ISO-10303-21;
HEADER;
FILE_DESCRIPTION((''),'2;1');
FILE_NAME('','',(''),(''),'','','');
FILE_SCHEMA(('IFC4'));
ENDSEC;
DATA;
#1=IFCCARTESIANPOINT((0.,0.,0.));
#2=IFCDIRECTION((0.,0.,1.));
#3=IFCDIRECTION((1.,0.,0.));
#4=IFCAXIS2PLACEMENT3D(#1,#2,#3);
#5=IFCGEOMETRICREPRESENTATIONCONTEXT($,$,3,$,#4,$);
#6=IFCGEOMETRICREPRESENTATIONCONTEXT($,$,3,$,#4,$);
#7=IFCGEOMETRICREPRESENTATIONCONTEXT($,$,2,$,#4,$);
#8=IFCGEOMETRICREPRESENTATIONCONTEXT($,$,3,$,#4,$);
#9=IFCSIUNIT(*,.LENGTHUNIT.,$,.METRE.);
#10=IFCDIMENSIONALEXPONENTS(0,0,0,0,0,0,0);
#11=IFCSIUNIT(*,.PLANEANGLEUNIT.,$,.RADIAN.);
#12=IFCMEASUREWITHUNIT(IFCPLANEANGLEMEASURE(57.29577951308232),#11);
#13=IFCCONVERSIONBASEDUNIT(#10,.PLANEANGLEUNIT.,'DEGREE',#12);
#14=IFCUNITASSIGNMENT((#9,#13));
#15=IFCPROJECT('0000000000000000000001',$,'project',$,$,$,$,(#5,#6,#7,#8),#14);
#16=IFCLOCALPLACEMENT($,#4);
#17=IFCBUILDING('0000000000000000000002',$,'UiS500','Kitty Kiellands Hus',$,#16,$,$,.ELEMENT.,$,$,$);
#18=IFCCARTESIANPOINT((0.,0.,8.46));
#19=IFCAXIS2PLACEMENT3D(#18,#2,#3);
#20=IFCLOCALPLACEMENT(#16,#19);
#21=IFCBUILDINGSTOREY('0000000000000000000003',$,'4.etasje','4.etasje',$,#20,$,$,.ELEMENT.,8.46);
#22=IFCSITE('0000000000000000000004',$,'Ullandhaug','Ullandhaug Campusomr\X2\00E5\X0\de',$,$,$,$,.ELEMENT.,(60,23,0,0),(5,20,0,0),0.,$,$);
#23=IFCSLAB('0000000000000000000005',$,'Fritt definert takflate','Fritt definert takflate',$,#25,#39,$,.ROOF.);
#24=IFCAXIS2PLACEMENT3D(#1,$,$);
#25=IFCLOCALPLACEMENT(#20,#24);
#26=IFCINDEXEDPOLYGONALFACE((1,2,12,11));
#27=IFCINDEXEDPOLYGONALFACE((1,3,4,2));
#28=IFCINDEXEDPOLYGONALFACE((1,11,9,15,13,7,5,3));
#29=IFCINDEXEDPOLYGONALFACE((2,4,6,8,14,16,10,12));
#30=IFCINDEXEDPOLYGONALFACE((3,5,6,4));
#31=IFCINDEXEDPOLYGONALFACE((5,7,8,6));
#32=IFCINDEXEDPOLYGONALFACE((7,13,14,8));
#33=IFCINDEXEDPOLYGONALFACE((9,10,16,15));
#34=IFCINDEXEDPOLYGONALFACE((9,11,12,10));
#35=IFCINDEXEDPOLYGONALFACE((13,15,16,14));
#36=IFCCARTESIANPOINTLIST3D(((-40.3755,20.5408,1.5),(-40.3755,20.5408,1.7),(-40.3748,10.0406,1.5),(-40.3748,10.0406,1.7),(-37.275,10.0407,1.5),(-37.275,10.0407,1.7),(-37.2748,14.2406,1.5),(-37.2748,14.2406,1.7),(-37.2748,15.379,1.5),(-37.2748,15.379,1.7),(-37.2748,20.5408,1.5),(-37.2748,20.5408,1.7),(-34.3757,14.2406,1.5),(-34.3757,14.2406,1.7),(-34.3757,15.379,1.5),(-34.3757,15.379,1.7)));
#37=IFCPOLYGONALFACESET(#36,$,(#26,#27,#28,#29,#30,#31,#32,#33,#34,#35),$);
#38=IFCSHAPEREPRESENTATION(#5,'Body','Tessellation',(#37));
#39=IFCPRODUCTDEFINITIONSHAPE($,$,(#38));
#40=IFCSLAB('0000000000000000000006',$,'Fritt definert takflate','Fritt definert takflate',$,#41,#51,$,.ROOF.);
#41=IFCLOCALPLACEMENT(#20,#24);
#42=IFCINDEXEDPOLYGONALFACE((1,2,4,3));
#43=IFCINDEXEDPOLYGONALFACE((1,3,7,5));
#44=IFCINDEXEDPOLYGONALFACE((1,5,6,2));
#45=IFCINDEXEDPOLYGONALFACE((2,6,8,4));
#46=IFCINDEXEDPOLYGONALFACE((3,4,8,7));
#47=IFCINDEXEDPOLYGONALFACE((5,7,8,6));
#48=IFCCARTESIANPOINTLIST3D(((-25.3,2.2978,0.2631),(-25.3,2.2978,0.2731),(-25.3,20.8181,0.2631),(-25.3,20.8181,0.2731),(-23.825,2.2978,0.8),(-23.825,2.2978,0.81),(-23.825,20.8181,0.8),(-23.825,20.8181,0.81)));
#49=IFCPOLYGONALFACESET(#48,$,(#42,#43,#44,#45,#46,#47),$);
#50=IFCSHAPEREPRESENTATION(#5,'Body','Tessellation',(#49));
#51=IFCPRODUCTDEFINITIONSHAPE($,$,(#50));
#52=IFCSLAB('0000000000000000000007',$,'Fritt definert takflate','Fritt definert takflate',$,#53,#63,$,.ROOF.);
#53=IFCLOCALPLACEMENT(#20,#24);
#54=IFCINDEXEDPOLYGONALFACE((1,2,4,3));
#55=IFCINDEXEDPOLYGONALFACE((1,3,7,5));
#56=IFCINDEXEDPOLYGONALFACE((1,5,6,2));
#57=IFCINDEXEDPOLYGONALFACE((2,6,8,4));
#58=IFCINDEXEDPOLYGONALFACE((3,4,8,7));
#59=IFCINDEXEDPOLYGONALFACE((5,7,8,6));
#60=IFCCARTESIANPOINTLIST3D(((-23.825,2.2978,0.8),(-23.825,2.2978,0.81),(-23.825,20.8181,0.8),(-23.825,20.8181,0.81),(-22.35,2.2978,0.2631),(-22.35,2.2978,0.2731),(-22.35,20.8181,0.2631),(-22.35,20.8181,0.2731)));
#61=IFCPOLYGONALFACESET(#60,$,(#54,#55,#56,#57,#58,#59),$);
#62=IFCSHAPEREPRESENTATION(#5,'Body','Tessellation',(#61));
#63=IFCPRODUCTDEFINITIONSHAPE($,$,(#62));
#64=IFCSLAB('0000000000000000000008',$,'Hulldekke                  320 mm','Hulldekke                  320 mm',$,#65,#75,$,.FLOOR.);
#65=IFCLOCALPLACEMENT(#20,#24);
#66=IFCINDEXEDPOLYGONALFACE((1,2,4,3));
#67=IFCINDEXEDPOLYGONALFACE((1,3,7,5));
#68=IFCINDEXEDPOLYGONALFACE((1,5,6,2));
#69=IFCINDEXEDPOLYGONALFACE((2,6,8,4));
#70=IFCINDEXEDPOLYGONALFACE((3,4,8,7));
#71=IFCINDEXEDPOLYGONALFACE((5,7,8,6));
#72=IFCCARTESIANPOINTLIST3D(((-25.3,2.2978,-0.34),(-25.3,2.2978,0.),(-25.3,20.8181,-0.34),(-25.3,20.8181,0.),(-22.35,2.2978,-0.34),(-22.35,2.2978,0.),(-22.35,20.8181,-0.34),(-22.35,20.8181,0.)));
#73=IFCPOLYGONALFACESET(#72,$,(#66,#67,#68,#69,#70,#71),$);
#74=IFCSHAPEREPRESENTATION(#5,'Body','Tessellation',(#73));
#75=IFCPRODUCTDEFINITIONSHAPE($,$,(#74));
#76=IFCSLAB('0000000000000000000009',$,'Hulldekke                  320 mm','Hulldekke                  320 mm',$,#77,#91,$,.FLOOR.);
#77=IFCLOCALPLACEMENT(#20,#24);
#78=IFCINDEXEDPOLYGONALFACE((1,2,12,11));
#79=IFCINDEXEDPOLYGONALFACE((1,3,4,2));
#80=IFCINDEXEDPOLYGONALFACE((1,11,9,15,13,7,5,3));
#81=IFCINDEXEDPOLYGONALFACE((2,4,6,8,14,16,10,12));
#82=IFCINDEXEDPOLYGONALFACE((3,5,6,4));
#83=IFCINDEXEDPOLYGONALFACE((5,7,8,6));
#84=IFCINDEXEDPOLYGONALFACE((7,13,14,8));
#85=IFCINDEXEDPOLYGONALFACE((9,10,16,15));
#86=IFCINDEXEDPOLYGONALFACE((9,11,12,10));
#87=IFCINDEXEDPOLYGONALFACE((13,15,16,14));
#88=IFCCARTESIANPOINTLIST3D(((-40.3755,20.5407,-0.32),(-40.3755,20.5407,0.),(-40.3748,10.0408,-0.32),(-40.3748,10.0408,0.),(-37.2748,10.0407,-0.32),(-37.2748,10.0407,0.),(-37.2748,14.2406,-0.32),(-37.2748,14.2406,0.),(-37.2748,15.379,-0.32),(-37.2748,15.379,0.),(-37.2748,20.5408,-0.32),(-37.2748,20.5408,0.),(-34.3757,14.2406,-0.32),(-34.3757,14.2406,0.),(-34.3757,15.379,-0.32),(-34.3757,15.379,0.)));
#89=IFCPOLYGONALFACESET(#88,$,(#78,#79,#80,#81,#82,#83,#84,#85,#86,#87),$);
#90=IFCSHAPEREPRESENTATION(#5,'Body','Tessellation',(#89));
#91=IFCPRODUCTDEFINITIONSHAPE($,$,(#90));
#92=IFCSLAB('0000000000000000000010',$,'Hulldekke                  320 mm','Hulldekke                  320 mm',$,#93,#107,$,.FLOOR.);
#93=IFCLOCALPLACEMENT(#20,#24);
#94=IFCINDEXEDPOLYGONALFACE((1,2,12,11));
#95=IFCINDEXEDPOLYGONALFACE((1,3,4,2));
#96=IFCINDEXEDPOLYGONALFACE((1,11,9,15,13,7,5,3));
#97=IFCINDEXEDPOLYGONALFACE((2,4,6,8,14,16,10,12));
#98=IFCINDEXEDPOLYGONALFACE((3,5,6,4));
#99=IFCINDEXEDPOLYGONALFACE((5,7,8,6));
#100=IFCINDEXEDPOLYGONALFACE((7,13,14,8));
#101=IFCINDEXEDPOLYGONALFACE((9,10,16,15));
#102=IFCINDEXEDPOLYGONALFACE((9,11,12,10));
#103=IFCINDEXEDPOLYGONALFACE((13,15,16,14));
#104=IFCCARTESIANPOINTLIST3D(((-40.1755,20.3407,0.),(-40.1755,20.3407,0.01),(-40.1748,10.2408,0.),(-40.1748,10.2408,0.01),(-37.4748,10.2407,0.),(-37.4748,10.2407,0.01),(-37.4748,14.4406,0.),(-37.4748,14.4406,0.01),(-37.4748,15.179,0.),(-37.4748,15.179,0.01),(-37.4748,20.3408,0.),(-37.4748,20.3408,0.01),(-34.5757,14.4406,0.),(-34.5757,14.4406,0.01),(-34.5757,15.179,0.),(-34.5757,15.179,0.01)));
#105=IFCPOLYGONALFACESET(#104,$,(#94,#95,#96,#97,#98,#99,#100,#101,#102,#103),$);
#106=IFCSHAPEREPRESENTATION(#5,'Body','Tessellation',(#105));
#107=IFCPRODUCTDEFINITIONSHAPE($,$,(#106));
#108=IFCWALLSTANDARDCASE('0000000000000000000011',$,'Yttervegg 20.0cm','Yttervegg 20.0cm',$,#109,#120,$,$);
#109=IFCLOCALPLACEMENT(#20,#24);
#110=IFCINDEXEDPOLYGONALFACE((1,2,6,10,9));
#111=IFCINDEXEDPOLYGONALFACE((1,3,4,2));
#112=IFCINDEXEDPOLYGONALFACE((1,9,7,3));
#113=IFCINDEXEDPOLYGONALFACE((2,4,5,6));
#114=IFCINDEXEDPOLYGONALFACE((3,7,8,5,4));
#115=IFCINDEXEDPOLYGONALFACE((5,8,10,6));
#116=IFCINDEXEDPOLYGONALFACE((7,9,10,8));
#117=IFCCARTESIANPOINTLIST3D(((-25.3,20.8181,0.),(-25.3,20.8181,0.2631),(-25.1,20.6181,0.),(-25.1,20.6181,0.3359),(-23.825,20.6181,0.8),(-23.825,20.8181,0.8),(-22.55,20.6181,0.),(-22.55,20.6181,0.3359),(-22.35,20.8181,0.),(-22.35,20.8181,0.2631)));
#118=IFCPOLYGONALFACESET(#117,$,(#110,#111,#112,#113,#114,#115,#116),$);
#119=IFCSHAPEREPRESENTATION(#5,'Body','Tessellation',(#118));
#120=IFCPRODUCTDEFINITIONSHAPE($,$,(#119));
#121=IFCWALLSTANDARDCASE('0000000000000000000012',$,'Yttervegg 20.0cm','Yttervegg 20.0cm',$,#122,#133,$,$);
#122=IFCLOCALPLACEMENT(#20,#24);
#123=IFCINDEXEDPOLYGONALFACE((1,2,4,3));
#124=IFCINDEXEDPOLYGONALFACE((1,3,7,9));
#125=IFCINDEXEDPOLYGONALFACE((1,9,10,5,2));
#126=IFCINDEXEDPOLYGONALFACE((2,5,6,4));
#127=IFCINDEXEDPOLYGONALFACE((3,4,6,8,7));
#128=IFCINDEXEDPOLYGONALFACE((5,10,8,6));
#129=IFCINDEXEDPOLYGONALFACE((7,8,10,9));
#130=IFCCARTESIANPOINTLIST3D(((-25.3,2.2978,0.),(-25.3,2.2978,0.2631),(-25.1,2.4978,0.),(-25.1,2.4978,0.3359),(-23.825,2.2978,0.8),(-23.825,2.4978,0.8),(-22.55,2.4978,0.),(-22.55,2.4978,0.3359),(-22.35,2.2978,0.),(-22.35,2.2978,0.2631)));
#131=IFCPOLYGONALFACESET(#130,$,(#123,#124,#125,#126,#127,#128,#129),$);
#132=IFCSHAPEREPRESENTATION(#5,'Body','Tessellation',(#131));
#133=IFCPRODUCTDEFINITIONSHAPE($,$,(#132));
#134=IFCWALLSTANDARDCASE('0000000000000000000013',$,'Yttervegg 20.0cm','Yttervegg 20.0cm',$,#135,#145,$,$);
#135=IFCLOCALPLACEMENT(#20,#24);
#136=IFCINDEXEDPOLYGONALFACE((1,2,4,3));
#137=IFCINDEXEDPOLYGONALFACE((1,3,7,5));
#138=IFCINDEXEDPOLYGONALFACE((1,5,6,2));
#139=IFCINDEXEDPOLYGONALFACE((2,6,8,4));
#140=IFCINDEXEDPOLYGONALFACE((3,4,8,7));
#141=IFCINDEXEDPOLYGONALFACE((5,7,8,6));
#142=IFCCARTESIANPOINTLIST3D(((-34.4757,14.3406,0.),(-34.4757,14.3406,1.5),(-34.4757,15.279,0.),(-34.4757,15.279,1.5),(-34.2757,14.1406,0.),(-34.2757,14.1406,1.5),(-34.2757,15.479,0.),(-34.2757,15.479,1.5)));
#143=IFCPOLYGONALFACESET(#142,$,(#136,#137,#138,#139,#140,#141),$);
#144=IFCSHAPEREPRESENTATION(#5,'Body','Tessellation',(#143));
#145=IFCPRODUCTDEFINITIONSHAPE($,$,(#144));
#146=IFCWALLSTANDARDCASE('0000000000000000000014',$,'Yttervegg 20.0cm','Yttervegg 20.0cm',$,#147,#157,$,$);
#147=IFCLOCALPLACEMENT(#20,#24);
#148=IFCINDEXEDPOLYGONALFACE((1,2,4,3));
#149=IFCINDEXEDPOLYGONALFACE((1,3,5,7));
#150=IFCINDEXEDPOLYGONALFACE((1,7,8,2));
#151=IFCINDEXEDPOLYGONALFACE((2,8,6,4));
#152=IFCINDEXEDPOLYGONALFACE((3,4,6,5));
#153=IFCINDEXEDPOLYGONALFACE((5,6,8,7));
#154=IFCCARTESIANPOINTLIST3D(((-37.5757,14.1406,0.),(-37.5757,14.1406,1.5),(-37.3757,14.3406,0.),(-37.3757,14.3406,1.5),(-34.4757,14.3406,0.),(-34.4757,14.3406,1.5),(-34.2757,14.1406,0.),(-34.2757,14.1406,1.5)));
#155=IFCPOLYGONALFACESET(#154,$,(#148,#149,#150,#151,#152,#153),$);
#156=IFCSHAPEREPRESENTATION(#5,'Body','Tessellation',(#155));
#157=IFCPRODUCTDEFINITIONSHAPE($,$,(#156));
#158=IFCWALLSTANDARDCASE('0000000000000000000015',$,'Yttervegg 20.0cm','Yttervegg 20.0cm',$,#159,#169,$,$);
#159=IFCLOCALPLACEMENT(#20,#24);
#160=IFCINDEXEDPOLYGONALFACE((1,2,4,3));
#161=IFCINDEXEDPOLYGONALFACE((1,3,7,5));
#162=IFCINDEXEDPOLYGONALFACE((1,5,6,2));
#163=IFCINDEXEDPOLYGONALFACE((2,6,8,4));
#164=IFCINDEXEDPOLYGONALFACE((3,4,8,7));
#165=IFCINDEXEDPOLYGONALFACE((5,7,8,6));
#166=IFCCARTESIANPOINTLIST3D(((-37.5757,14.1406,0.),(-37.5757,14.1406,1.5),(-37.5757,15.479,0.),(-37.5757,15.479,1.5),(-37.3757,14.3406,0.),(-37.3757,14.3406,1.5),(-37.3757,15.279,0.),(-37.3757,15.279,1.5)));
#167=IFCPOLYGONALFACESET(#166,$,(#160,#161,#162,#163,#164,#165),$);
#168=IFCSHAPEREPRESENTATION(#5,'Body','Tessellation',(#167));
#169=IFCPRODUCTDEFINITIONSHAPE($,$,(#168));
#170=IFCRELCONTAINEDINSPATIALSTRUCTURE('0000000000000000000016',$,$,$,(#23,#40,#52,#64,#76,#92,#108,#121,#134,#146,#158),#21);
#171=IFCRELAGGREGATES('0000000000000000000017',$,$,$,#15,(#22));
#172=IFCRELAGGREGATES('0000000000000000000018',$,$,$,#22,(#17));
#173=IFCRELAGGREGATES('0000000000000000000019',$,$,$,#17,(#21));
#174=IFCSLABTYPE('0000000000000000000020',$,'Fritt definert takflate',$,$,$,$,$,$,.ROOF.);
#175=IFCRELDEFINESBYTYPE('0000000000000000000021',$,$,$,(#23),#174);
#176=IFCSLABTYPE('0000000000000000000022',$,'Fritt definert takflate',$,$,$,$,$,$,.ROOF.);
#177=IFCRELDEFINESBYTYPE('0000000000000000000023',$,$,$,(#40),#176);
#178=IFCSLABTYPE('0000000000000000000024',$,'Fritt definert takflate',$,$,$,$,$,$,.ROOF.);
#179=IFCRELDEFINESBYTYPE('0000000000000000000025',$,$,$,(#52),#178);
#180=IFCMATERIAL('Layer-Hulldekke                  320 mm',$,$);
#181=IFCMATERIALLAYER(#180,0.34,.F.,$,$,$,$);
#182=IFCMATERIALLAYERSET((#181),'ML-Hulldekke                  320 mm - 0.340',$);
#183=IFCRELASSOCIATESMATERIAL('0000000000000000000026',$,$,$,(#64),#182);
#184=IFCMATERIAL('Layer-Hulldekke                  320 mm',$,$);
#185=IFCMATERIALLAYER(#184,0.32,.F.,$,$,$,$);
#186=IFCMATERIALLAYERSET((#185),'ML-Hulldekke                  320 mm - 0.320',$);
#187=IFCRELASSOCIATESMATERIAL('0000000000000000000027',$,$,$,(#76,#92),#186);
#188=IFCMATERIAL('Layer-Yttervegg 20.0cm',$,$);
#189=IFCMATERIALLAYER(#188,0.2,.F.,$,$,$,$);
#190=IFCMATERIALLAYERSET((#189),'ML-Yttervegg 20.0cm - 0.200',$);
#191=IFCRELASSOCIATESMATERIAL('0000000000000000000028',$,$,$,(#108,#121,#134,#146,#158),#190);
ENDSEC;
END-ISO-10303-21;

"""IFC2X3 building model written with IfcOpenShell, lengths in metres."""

from ifc_helpers import new_model, entity, si_unit, converted_unit, frame, origin_with_axes, place, context, project, spatial, polyline, outline, extrude, clip, bounded_halfspace, material, layer, layer_set, layer_usage, type_object, element, save


model = new_model("IFC2X3")

# Units and contexts
context_of_model_1 = context(None, 3, world=origin_with_axes())
context_of_model_2 = context(None, 3, world=origin_with_axes())
context_of_model_3 = context(None, 2, world=origin_with_axes())
context_of_model_4 = context(None, 3, world=origin_with_axes())
ifc_project = project(units=[si_unit("LENGTHUNIT", "METRE"), converted_unit("PLANEANGLEUNIT", "DEGREE", entity("IfcPlaneAngleMeasure", 57.29577951308232), si_unit("PLANEANGLEUNIT", "RADIAN"), dimensions=[0, 0, 0, 0, 0, 0, 0])], contexts=[context_of_model_1, context_of_model_2, context_of_model_3, context_of_model_4])

# Site, building, storey
site = spatial("IfcSite", under=ifc_project, Name="Ullandhaug", Description="Ullandhaug Campusområde", CompositionType="ELEMENT", RefLatitude=(60, 23, 0, 0), RefLongitude=(5, 20, 0, 0), RefElevation=0.0)
building_placement = place(None, origin_with_axes())
building = spatial("IfcBuilding", under=site, at=building_placement, Name="UiS500", Description="Kitty Kiellands Hus", CompositionType="ELEMENT")
storey_placement = place(building_placement, frame((0.0, 0.0, 8.46), z_axis=(0.0, 0.0, 1.0), x_axis=(1.0, 0.0, 0.0)))
storey = spatial("IfcBuildingStorey", under=building, at=storey_placement, Name="4.etasje", Description="4.etasje", CompositionType="ELEMENT", Elevation=8.46)

# Slabs
slab_type_1 = type_object("IfcSlabType", Name="Fritt definert takflate", PredefinedType="ROOF")
slab_1_placement = place(storey_placement, frame((-37.2748, 20.5408, 1.5), z_axis=(0.0, 0.0, 1.0), x_axis=(-1.0, 0.0, 0.0)))
element("IfcSlab", 1, at=slab_1_placement, inside=storey, type_object=slab_type_1, Name="Fritt definert takflate", Description="Fritt definert takflate", PredefinedType="ROOF", context=context_of_model_1, shape_type="SweptSolid", body=[
    extrude(outline(polyline([(0.0, 0.0), (3.1006, 0.0), (3.1, 10.5003), (0.0001, 10.5001), (0.0, 6.3003), (-2.8991, 6.3003), (-2.8991, 5.1619), (0.0, 5.1619), (0.0, 0.0)])), origin_with_axes(), (0.0, 0.0, 1.0), 0.2),
])
slab_type_2 = type_object("IfcSlabType", Name="Fritt definert takflate", PredefinedType="ROOF")
slab_2_placement = place(storey_placement, frame((-23.825, 2.2978, 0.8), z_axis=(-0.34202, 0.0, 0.939693), x_axis=(0.0, 1.0, 0.0)))
element("IfcSlab", 2, at=slab_2_placement, inside=storey, type_object=slab_type_2, Name="Fritt definert takflate", Description="Fritt definert takflate", PredefinedType="ROOF", context=context_of_model_1, shape_type="SweptSolid", body=[
    extrude(outline(polyline([(0.0, 0.0), (18.5203, 0.0), (18.5203, 1.5697), (0.0, 1.5697), (0.0, 0.0)])), origin_with_axes(), (0.0, -0.34202, 0.939693), 0.01),
])
slab_type_3 = type_object("IfcSlabType", Name="Fritt definert takflate", PredefinedType="ROOF")
slab_3_placement = place(storey_placement, frame((-23.825, 20.8181, 0.8), z_axis=(0.34202, 0.0, 0.939693), x_axis=(0.0, -1.0, 0.0)))
element("IfcSlab", 3, at=slab_3_placement, inside=storey, type_object=slab_type_3, Name="Fritt definert takflate", Description="Fritt definert takflate", PredefinedType="ROOF", context=context_of_model_1, shape_type="SweptSolid", body=[
    extrude(outline(polyline([(0.0, 0.0), (18.5203, 0.0), (18.5203, 1.5697), (0.0, 1.5697), (0.0, 0.0)])), origin_with_axes(), (0.0, -0.34202, 0.939693), 0.01),
])
ifc_material_1 = material(Name="Layer-Hulldekke                  320 mm")
ifc_layer_1 = layer(ifc_material_1, 0.34, ventilated=False)
ifc_layer_set_1 = layer_set([ifc_layer_1], Name="ML-Hulldekke                  320 mm - 0.340")
ifc_layer_usage_1 = layer_usage(ifc_layer_set_1, "AXIS2", "POSITIVE", 0.0)
slab_4_placement = place(storey_placement, frame((-22.35, 20.8181, 0.0), z_axis=(0.0, 0.0, 1.0), x_axis=(1.0, 0.0, 0.0)))
element("IfcSlab", 4, at=slab_4_placement, inside=storey, material=ifc_layer_usage_1, Name="Hulldekke                  320 mm", Description="Hulldekke                  320 mm", PredefinedType="FLOOR", context=context_of_model_1, shape_type="SweptSolid", body=[
    extrude(outline(polyline([(0.0, 0.0), (2.95, 0.0), (2.95, 18.5203), (0.0, 18.5203), (0.0, 0.0)])), frame((0.0, 0.0, 0.0), z_axis=(0.0, 0.0, 1.0), x_axis=(-1.0, 0.0, 0.0)), (0.0, 0.0, -1.0), 0.34),
])
ifc_material_2 = material(Name="Layer-Hulldekke                  320 mm")
ifc_layer_2 = layer(ifc_material_2, 0.32, ventilated=False)
ifc_layer_set_2 = layer_set([ifc_layer_2], Name="ML-Hulldekke                  320 mm - 0.320")
ifc_layer_usage_2 = layer_usage(ifc_layer_set_2, "AXIS2", "POSITIVE", 0.0)
slab_5_placement = place(storey_placement, frame((-40.3748, 10.0408, 0.0), z_axis=(0.0, 0.0, 1.0), x_axis=(1.0, 0.0, 0.0)))
element("IfcSlab", 5, at=slab_5_placement, inside=storey, material=ifc_layer_usage_2, Name="Hulldekke                  320 mm", Description="Hulldekke                  320 mm", PredefinedType="FLOOR", context=context_of_model_1, shape_type="SweptSolid", body=[
    extrude(outline(polyline([(0.0, 0.0), (3.1, 0.0), (3.0999, 4.1998), (5.9989, 4.1999), (5.9989, 5.3383), (3.0998, 5.3382), (3.0996, 10.5001), (-0.001, 10.4998), (0.0, 0.0)])), frame((0.0, 0.0, 0.0), z_axis=(0.0, 0.0, 1.0), x_axis=(1.0, -0.000034, 0.0)), (0.0, 0.0, -1.0), 0.32),
])
slab_6_placement = place(storey_placement, frame((-40.1748, 10.2408, 0.0), z_axis=(0.0, 0.0, 1.0), x_axis=(1.0, 0.0, 0.0)))
element("IfcSlab", 6, at=slab_6_placement, inside=storey, material=ifc_layer_usage_2, Name="Hulldekke                  320 mm", Description="Hulldekke                  320 mm", PredefinedType="FLOOR", context=context_of_model_1, shape_type="SweptSolid", body=[
    extrude(outline(polyline([(0.0, 0.0), (2.7, 0.0), (2.6999, 4.1998), (5.599, 4.1999), (5.5989, 4.9383), (2.6998, 4.9382), (2.6997, 10.1001), (-0.001, 10.0998), (0.0, 0.0)])), frame((0.0, 0.0, 0.0), z_axis=(0.0, 0.0, 1.0), x_axis=(1.0, -0.000034, 0.0)), (0.0, 0.0, 1.0), 0.01),
])

# Walls
ifc_material_3 = material(Name="Layer-Yttervegg 20.0cm")
ifc_layer_3 = layer(ifc_material_3, 0.2, ventilated=False)
ifc_layer_set_3 = layer_set([ifc_layer_3], Name="ML-Yttervegg 20.0cm - 0.200")
ifc_layer_usage_3 = layer_usage(ifc_layer_set_3, "AXIS2", "POSITIVE", 0.0)
wall_1_placement = place(storey_placement, frame((-22.35, 20.8181, 0.0), z_axis=(0.0, 0.0, 1.0), x_axis=(-1.0, 0.0, 0.0)))
element("IfcWallStandardCase", 7, at=wall_1_placement, inside=storey, material=ifc_layer_usage_3, Name="Yttervegg 20.0cm", Description="Yttervegg 20.0cm", context=context_of_model_1, shape_type="Clipping", body=[
    clip(clip(extrude(outline(polyline([(0.0, 0.0), (2.95, 0.0), (2.75, 0.2), (0.2, 0.2), (0.0, 0.0)])), frame((0.0, 0.0, 0.0), z_axis=(0.0, 0.0, 1.0), x_axis=(1.0, 0.0, 0.0)), (0.0, 0.0, 1.0), 0.8), bounded_halfspace(frame((1.475, 0.0, 0.8), z_axis=(0.34202, 0.0, -0.939693), x_axis=(0.0, -1.0, 0.0)), True, frame((1.475, 0.0, 0.0), z_axis=(0.0, 0.0, 1.0), x_axis=(1.0, 0.0, 0.0)), polyline([(0.0, 0.0), (0.0, 18.5203), (-1.475, 18.5203), (-1.475, 0.0), (0.0, 0.0)]))), bounded_halfspace(frame((1.475, 18.5203, 0.8), z_axis=(-0.34202, 0.0, -0.939693), x_axis=(0.0, 1.0, 0.0)), True, frame((1.475, 18.5203, 0.0), z_axis=(0.0, 0.0, 1.0), x_axis=(1.0, 0.0, 0.0)), polyline([(0.0, 0.0), (0.0, -18.5203), (1.475, -18.5203), (1.475, 0.0), (0.0, 0.0)]))),
])
wall_2_placement = place(storey_placement, frame((-25.3, 2.2978, 0.0), z_axis=(0.0, 0.0, 1.0), x_axis=(1.0, 0.0, 0.0)))
element("IfcWallStandardCase", 8, at=wall_2_placement, inside=storey, material=ifc_layer_usage_3, Name="Yttervegg 20.0cm", Description="Yttervegg 20.0cm", context=context_of_model_1, shape_type="Clipping", body=[
    clip(clip(extrude(outline(polyline([(0.0, 0.0), (2.95, 0.0), (2.75, 0.2), (0.2, 0.2), (0.0, 0.0)])), origin_with_axes(), (0.0, 0.0, 1.0), 0.8), bounded_halfspace(frame((1.475, 18.5203, 0.8), z_axis=(-0.34202, 0.0, -0.939693), x_axis=(0.0, 1.0, 0.0)), True, frame((1.475, 18.5203, 0.0), z_axis=(0.0, 0.0, 1.0), x_axis=(1.0, 0.0, 0.0)), polyline([(0.0, 0.0), (0.0, -18.5203), (1.475, -18.5203), (1.475, 0.0), (0.0, 0.0)]))), bounded_halfspace(frame((1.475, 0.0, 0.8), z_axis=(0.34202, 0.0, -0.939693), x_axis=(0.0, -1.0, 0.0)), True, frame((1.475, 0.0, 0.0), z_axis=(0.0, 0.0, 1.0), x_axis=(1.0, 0.0, 0.0)), polyline([(0.0, 0.0), (0.0, 18.5203), (-1.475, 18.5203), (-1.475, 0.0), (0.0, 0.0)]))),
])
wall_3_placement = place(storey_placement, frame((-34.4757, 15.279, 0.0), z_axis=(0.0, 0.0, 1.0), x_axis=(0.0, -1.0, 0.0)))
element("IfcWallStandardCase", 9, at=wall_3_placement, inside=storey, material=ifc_layer_usage_3, Name="Yttervegg 20.0cm", Description="Yttervegg 20.0cm", context=context_of_model_1, shape_type="SweptSolid", body=[
    extrude(outline(polyline([(0.0, 0.0), (0.9384, 0.0), (1.1384, 0.2), (-0.2, 0.2), (0.0, 0.0)])), frame((0.0, 0.0, 0.0), z_axis=(0.0, 0.0, 1.0), x_axis=(1.0, 0.0, 0.0)), (0.0, 0.0, 1.0), 1.5),
])
wall_4_placement = place(storey_placement, frame((-34.4757, 14.3406, 0.0), z_axis=(0.0, 0.0, 1.0), x_axis=(-1.0, 0.0, 0.0)))
element("IfcWallStandardCase", 10, at=wall_4_placement, inside=storey, material=ifc_layer_usage_3, Name="Yttervegg 20.0cm", Description="Yttervegg 20.0cm", context=context_of_model_1, shape_type="SweptSolid", body=[
    extrude(outline(polyline([(0.0, 0.0), (2.9, 0.0), (3.1, 0.2), (-0.2, 0.2), (0.0, 0.0)])), frame((0.0, 0.0, 0.0), z_axis=(0.0, 0.0, 1.0), x_axis=(1.0, 0.0, 0.0)), (0.0, 0.0, 1.0), 1.5),
])
wall_5_placement = place(storey_placement, frame((-37.3757, 14.3406, 0.0), z_axis=(0.0, 0.0, 1.0), x_axis=(0.0, 1.0, 0.0)))
element("IfcWallStandardCase", 11, at=wall_5_placement, inside=storey, material=ifc_layer_usage_3, Name="Yttervegg 20.0cm", Description="Yttervegg 20.0cm", context=context_of_model_1, shape_type="SweptSolid", body=[
    extrude(outline(polyline([(0.0, 0.0), (0.9384, 0.0), (1.1384, 0.2), (-0.2, 0.2), (0.0, 0.0)])), frame((0.0, 0.0, 0.0), z_axis=(0.0, 0.0, 1.0), x_axis=(1.0, 0.0, 0.0)), (0.0, 0.0, 1.0), 1.5),
])

save(model, "model.ifc")
